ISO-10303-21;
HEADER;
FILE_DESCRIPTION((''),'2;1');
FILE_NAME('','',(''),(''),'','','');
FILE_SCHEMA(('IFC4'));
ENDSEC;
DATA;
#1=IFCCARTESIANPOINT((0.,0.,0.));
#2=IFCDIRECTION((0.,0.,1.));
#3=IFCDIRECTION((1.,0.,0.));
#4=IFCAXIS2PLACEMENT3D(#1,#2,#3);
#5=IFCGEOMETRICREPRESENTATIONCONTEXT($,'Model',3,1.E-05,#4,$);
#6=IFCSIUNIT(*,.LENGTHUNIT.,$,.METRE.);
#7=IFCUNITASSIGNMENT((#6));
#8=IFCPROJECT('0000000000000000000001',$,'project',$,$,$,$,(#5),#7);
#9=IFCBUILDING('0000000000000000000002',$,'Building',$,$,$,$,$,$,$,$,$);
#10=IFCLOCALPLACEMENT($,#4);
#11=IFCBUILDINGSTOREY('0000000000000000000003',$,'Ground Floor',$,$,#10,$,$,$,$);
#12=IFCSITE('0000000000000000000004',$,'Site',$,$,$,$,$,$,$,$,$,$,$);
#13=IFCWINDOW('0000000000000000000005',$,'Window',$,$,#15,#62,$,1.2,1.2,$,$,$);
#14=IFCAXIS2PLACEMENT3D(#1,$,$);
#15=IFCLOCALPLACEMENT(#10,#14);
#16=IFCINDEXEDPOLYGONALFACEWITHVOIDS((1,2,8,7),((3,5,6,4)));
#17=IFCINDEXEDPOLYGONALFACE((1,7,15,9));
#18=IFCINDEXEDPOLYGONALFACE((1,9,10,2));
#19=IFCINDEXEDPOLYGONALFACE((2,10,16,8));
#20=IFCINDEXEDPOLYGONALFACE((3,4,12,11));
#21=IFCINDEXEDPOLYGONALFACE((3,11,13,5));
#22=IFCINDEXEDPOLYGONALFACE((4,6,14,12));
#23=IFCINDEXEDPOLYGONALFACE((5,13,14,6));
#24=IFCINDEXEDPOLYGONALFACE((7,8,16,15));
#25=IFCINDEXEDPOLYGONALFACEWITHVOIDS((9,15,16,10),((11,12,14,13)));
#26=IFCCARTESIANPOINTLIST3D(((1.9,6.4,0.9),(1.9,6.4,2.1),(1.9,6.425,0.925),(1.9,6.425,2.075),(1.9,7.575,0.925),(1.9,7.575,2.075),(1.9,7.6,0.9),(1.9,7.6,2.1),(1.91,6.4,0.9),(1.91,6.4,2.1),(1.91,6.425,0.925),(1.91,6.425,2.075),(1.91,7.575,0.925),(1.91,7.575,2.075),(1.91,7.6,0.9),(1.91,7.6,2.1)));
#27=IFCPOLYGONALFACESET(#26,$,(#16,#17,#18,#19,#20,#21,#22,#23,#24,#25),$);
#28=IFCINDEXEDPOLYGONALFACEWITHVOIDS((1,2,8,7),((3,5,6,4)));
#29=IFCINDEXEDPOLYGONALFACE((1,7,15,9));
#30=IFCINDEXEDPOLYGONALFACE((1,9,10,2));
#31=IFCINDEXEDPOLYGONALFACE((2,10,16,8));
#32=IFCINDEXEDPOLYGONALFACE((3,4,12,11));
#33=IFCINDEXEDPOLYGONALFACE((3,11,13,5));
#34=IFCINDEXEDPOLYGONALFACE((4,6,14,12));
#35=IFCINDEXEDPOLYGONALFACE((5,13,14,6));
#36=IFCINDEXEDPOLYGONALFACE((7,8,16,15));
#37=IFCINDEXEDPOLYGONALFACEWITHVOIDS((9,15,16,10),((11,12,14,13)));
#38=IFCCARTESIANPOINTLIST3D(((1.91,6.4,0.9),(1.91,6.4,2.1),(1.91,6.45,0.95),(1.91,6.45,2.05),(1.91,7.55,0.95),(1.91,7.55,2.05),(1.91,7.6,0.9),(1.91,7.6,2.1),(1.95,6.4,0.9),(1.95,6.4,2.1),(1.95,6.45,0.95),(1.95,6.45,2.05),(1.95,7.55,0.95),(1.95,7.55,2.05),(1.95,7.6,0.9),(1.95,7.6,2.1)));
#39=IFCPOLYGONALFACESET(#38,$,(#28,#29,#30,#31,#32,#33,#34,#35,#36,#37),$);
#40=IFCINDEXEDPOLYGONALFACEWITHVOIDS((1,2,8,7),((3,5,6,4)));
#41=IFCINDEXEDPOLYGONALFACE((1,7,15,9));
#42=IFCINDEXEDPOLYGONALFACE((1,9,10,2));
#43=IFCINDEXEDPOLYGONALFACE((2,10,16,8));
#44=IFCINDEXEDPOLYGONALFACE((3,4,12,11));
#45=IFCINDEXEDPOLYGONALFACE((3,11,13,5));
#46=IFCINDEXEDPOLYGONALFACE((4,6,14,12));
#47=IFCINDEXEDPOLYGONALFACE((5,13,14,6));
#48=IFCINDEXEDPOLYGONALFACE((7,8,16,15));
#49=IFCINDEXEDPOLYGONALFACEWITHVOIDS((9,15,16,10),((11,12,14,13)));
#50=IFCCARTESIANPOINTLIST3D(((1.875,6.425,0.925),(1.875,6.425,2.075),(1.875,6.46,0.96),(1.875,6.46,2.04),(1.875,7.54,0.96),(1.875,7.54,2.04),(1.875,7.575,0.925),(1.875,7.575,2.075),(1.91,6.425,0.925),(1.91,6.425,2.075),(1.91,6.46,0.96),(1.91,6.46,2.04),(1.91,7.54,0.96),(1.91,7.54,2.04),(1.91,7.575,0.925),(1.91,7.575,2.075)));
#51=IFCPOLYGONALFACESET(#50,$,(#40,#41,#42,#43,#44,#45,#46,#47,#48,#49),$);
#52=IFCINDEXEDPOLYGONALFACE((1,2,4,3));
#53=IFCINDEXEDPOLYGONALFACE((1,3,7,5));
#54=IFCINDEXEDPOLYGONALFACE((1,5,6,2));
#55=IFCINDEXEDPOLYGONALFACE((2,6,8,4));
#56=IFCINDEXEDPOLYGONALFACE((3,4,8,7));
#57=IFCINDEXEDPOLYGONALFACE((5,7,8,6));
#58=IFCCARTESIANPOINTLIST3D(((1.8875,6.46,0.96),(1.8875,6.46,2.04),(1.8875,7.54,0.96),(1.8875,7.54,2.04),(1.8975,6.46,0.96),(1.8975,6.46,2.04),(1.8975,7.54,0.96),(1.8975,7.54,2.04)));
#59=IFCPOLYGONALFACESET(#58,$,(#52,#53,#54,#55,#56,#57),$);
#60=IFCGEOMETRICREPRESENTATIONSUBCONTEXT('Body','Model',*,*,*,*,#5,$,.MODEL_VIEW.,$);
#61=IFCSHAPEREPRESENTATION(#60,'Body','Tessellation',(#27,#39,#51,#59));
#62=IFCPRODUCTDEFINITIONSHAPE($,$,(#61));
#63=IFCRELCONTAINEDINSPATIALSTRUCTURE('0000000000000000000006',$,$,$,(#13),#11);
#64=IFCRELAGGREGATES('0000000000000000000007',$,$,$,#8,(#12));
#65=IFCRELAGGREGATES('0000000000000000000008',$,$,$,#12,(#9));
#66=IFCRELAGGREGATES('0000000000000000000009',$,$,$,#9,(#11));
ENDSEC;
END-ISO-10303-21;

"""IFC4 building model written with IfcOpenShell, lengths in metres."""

from ifc_helpers import new_model, si_unit, frame, origin_with_axes, place, context, subcontext, project, spatial, line, indexed_curve, outline, extrude, element, save


model = new_model("IFC4")

# Units and contexts
model_context = context("Model", 3, precision=1e-05, world=origin_with_axes())
body_context = subcontext(model_context, "Body", "Model", "MODEL_VIEW")
ifc_project = project(units=[si_unit("LENGTHUNIT", "METRE")], contexts=[model_context])

# Site, building, storey
site = spatial("IfcSite", under=ifc_project, Name="Site")
building = spatial("IfcBuilding", under=site, Name="Building")
storey_placement = place(None, origin_with_axes())
storey = spatial("IfcBuildingStorey", under=building, at=storey_placement, Name="Ground Floor")

# Window
window_placement = place(storey_placement, frame((2.0, 6.4, 0.9), z_axis=(0.0, 0.0, 1.0), x_axis=(0.0, 1.0, 0.0)))
element("IfcWindow", 1, at=window_placement, inside=storey, Name="Window", OverallHeight=1.2, OverallWidth=1.2, context=body_context, shape_type="SweptSolid", body=[
    extrude(outline(indexed_curve([(0.0, 0.0), (1.2, 0.0), (1.2, 1.2), (0.0, 1.2)], segments=[line(1, 2, 3, 4, 1)]), holes=[indexed_curve([(0.025, 0.025), (1.175, 0.025), (1.175, 1.175), (0.025, 1.175)], segments=[line(1, 2, 3, 4, 1)])]), frame((0.0, 0.09, 0.0), z_axis=(0.0, -1.0, 0.0), x_axis=(1.0, 0.0, 0.0)), (0.0, 0.0, -1.0), 0.01),
    extrude(outline(indexed_curve([(0.0, 0.0), (1.2, 0.0), (1.2, 1.2), (0.0, 1.2)], segments=[line(1, 2, 3, 4, 1)]), holes=[indexed_curve([(0.05, 0.05), (1.15, 0.05), (1.15, 1.15), (0.05, 1.15)], segments=[line(1, 2, 3, 4, 1)])]), frame((0.0, 0.05, 0.0), z_axis=(0.0, -1.0, 0.0), x_axis=(1.0, 0.0, 0.0)), (0.0, 0.0, -1.0), 0.04),
    extrude(outline(indexed_curve([(0.0, 0.0), (1.15, 0.0), (1.15, 1.15), (0.0, 1.15)], segments=[line(1, 2, 3, 4, 1)]), holes=[indexed_curve([(0.035, 0.035), (1.115, 0.035), (1.115, 1.115), (0.035, 1.115)], segments=[line(1, 2, 3, 4, 1)])]), frame((0.025, 0.09, 0.025), z_axis=(0.0, -1.0, 0.0), x_axis=(1.0, 0.0, 0.0)), (0.0, 0.0, -1.0), 0.035),
    extrude(outline(indexed_curve([(0.035, 0.035), (1.115, 0.035), (1.115, 1.115), (0.035, 1.115)], segments=[line(1, 2, 3, 4, 1)])), frame((0.025, 0.1025, 0.025), z_axis=(0.0, -1.0, 0.0), x_axis=(1.0, 0.0, 0.0)), (0.0, 0.0, -1.0), 0.01),
])

save(model, "model.ifc")
